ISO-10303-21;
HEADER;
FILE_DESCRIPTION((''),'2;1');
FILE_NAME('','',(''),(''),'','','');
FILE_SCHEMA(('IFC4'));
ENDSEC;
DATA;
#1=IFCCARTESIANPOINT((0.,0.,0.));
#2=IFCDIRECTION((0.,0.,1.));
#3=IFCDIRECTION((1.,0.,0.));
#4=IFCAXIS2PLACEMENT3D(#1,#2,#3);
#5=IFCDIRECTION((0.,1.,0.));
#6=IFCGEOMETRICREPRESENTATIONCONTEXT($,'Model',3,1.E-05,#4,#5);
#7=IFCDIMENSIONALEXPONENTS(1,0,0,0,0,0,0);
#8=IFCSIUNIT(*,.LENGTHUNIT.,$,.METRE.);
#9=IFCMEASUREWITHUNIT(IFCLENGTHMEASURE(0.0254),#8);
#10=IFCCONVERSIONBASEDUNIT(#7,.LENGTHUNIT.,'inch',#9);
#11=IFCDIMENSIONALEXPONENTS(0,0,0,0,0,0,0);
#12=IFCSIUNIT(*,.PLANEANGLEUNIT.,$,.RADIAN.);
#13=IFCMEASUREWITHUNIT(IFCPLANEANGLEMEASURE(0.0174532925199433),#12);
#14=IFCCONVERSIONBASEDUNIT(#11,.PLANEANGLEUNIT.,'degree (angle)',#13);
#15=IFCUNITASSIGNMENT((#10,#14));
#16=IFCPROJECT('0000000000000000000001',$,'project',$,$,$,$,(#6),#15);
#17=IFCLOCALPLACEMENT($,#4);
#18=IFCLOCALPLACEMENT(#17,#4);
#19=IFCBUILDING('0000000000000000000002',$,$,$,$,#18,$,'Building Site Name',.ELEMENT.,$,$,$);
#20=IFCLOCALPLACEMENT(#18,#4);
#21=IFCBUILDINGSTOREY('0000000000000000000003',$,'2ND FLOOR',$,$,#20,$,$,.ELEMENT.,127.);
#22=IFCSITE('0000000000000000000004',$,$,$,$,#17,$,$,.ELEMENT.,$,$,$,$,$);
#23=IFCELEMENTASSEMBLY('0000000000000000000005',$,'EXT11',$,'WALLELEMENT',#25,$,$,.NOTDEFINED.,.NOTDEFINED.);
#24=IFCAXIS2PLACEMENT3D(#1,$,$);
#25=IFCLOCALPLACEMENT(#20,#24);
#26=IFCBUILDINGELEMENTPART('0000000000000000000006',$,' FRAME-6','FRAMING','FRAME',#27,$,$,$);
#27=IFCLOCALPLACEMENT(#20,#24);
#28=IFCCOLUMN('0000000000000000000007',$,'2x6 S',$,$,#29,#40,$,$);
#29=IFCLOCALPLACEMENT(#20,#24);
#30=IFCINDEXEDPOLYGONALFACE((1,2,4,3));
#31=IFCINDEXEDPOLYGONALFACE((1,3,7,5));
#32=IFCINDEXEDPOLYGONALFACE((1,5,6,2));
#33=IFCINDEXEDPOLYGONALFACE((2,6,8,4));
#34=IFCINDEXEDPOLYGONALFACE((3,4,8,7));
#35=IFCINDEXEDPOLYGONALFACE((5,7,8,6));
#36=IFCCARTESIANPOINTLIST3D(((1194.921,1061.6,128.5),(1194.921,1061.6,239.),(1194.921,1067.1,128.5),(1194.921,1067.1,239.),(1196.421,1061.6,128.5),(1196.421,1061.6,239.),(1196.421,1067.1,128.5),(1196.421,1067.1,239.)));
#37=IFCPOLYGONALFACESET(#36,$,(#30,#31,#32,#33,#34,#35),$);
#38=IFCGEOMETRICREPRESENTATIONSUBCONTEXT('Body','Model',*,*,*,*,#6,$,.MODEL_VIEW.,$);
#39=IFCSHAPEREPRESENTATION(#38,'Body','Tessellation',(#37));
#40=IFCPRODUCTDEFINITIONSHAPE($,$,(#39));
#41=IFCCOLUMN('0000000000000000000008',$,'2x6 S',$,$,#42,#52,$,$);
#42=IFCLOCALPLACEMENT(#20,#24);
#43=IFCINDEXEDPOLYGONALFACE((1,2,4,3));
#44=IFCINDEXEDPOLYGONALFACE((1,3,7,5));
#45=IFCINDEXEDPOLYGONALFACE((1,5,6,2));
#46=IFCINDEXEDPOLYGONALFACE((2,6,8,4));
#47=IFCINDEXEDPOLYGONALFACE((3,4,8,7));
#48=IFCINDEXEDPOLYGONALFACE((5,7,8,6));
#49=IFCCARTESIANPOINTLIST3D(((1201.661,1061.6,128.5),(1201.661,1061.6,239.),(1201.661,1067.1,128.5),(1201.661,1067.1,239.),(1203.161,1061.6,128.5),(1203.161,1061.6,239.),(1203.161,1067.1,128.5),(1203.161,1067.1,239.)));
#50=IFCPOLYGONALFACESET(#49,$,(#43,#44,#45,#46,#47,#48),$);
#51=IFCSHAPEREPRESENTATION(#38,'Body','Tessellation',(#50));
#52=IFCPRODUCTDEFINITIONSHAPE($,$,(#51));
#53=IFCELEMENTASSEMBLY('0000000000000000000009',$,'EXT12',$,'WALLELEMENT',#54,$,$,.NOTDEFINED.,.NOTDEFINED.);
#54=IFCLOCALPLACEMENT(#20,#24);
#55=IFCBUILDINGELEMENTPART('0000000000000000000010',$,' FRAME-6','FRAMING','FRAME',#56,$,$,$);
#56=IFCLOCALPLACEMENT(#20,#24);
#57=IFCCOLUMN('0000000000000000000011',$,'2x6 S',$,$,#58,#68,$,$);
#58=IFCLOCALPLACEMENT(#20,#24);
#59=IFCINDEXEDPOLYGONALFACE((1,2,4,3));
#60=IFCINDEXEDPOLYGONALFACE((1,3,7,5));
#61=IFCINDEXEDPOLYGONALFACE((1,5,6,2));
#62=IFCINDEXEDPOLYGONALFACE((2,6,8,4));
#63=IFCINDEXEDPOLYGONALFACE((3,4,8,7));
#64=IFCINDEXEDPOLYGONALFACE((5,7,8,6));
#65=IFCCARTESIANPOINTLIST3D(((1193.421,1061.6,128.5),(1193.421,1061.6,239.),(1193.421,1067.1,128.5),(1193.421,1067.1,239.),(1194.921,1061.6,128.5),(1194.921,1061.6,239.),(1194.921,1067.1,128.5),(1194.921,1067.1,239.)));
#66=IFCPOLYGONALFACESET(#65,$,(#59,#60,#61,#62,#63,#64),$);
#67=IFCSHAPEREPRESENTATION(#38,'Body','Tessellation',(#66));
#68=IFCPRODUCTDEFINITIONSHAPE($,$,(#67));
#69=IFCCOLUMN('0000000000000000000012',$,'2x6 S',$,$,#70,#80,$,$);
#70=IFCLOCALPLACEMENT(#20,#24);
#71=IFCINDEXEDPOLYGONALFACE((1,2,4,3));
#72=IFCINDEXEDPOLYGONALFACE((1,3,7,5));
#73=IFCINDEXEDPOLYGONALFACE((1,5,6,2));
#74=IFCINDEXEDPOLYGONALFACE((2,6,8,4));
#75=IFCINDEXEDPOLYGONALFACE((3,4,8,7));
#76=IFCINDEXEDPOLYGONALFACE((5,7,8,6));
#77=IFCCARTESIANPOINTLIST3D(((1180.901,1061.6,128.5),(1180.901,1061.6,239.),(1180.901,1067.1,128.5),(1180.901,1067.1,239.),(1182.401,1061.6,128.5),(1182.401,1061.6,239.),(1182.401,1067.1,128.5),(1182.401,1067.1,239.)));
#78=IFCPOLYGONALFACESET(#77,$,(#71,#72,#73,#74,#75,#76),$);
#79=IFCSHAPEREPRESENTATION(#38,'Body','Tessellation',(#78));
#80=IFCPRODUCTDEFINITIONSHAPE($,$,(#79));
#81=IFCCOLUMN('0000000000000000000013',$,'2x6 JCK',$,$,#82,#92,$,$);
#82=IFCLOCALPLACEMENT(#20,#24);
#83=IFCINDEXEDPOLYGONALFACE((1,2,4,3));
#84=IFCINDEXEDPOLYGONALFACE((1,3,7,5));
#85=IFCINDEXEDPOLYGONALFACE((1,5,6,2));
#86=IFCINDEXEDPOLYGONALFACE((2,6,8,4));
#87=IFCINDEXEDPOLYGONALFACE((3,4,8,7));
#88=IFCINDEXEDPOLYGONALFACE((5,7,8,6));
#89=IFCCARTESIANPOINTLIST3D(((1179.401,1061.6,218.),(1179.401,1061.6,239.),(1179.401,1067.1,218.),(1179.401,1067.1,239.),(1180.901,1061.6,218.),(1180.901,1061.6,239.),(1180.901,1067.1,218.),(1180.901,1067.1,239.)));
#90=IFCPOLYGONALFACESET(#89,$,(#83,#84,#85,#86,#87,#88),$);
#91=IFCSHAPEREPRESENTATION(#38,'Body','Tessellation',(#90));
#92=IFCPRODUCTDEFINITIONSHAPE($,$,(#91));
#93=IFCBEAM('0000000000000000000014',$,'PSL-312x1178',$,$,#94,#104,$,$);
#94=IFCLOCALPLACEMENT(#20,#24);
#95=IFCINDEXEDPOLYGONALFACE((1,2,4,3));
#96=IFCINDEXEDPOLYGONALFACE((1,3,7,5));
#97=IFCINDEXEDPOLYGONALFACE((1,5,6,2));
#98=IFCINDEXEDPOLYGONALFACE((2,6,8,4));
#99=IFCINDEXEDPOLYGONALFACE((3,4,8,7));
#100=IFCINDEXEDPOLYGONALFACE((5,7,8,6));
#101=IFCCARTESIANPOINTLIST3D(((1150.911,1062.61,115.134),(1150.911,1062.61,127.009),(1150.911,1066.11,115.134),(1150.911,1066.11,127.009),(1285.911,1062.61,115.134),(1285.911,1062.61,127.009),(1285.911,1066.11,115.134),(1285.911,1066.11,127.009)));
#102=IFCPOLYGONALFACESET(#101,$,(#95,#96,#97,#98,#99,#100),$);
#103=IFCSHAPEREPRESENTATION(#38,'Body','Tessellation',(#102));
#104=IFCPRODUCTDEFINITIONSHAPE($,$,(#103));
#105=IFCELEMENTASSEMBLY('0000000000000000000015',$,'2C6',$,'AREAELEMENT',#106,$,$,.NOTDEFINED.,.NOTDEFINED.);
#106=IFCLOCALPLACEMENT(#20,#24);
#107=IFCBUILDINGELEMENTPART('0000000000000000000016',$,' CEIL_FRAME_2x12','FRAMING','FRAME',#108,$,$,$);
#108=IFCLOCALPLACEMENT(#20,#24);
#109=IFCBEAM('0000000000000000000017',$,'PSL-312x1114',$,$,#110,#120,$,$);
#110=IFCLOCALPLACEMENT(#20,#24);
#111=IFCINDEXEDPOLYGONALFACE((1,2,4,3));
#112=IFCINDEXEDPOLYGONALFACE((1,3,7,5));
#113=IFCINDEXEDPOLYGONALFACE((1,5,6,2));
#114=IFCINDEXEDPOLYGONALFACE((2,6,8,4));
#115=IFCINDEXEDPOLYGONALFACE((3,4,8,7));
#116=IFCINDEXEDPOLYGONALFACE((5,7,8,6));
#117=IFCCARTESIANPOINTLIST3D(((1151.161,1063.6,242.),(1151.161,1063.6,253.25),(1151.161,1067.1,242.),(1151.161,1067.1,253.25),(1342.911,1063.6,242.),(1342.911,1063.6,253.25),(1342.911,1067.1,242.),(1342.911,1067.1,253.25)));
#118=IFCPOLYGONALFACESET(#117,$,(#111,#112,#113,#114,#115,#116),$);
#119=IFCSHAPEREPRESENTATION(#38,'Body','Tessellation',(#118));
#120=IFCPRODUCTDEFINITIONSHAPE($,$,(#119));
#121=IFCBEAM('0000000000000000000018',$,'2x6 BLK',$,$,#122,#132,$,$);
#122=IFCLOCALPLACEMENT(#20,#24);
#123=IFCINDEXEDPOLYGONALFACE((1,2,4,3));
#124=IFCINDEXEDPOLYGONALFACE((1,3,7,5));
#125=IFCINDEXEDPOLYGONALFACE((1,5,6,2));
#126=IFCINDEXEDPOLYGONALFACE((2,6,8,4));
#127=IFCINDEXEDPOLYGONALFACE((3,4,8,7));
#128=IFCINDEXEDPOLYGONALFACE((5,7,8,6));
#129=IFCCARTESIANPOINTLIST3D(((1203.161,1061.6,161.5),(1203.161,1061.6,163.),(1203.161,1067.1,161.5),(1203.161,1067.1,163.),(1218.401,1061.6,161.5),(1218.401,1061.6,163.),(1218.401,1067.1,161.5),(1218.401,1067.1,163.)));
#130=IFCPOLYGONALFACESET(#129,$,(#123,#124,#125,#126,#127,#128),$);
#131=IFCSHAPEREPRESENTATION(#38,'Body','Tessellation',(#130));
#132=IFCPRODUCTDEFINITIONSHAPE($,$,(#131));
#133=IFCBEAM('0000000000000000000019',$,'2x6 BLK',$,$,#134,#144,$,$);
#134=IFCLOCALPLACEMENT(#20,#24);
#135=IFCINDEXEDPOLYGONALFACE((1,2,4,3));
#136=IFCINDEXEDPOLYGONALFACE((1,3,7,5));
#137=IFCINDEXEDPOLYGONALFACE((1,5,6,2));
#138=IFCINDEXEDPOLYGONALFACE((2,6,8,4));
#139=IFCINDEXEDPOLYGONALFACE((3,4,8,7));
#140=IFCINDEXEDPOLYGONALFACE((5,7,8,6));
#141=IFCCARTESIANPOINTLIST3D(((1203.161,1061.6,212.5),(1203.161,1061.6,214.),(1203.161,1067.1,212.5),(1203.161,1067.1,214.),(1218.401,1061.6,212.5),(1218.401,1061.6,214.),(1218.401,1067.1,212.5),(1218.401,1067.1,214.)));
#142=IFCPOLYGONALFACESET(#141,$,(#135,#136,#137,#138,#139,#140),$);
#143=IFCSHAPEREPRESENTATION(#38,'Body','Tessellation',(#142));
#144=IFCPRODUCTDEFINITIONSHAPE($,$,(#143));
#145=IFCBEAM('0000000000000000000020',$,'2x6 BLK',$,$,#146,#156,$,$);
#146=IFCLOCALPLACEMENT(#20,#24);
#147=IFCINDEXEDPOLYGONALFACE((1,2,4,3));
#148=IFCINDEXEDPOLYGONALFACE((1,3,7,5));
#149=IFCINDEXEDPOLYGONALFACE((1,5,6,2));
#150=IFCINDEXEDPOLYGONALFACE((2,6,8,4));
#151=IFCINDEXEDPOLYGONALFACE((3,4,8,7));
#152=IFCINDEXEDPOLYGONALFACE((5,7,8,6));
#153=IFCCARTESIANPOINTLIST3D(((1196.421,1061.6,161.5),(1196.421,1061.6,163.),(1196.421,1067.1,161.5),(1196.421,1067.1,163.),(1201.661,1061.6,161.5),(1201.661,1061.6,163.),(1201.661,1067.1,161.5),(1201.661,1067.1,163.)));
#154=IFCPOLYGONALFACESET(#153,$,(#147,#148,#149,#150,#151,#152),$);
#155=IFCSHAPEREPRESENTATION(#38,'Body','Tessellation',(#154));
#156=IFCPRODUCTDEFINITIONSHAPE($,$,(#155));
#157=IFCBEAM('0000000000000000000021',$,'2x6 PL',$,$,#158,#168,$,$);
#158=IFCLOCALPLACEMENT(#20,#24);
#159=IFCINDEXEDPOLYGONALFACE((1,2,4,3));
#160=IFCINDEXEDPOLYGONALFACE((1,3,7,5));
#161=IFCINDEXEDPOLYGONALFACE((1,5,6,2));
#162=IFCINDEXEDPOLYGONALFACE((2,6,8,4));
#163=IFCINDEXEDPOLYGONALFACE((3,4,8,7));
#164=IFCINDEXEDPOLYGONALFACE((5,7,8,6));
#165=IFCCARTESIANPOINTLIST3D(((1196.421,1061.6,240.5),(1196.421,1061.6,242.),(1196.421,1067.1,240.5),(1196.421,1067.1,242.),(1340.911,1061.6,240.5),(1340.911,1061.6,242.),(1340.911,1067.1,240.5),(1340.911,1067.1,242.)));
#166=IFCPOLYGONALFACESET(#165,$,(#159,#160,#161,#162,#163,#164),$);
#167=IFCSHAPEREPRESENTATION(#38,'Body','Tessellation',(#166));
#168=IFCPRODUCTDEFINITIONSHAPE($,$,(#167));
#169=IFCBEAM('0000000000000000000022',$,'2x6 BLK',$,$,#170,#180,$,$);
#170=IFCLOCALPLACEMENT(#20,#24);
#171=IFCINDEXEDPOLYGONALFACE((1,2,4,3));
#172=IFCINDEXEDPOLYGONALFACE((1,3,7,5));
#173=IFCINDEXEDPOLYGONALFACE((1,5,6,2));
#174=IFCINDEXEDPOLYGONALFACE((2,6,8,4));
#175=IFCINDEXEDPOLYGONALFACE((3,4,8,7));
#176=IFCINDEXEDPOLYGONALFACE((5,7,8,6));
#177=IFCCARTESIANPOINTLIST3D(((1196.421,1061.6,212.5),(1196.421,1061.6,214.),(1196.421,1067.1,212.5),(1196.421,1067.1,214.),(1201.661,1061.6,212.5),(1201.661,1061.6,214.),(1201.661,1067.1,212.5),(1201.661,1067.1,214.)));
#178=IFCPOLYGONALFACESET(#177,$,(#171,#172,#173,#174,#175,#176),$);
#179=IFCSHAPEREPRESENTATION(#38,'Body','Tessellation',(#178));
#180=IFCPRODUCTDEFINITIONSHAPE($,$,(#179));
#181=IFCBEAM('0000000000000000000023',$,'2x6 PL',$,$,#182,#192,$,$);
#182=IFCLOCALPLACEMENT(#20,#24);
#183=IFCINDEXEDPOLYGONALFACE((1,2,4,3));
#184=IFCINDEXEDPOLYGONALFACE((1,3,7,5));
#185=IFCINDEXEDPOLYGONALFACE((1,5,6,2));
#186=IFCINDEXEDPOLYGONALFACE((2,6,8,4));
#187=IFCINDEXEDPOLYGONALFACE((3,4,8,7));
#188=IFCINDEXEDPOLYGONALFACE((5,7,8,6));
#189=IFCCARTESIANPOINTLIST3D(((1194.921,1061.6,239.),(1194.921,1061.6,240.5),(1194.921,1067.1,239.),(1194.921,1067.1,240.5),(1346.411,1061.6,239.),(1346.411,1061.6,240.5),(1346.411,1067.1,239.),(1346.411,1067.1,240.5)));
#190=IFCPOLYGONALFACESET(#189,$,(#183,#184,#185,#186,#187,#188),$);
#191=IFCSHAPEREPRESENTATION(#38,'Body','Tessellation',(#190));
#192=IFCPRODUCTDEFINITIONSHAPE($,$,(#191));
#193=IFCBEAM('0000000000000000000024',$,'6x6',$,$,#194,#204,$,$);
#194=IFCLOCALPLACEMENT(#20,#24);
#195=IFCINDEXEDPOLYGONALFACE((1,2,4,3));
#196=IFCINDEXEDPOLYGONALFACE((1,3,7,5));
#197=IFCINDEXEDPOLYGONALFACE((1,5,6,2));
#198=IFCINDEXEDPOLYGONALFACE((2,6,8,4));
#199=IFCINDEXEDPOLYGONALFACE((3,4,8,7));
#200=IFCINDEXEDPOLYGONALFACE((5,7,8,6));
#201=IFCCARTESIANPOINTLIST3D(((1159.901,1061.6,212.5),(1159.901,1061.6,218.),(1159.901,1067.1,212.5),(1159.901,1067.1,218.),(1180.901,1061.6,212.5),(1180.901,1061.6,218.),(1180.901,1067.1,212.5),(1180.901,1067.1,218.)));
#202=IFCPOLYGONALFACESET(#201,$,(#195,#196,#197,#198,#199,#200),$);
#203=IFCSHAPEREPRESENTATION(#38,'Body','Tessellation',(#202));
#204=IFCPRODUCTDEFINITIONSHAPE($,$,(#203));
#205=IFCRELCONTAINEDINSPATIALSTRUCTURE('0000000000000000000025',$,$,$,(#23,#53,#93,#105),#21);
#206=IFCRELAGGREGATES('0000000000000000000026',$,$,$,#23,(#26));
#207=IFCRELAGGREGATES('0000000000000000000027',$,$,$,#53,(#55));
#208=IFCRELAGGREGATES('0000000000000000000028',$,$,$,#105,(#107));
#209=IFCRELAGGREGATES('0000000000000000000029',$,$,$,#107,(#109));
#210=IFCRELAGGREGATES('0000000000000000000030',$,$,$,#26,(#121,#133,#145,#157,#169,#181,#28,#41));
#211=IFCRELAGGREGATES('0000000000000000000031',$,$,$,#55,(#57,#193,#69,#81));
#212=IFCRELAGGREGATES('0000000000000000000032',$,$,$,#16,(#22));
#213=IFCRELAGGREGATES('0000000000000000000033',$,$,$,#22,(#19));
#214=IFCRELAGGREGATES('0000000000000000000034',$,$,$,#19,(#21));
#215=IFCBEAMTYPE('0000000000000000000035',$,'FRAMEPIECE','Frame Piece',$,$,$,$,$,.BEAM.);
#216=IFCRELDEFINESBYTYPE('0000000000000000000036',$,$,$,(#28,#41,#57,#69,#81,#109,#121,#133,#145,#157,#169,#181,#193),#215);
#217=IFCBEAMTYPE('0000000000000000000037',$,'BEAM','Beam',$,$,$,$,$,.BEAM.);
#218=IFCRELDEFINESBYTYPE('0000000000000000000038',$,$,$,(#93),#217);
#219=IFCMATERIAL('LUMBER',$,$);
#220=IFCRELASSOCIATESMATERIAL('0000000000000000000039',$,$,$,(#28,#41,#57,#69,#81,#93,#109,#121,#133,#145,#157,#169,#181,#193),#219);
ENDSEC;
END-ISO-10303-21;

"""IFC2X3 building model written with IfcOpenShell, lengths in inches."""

from ifc_helpers import new_model, entity, si_unit, converted_unit, direction, frame, frame_2d, origin_with_axes, place, context, subcontext, project, spatial, rectangle, extrude, material, type_object, element, aggregate, save


model = new_model("IFC2X3")

# Units and contexts
model_context = context("Model", 3, precision=1e-05, world=origin_with_axes(), true_north=direction((0.0, 1.0, 0.0)))
body_context = subcontext(model_context, "Body", "Model", "MODEL_VIEW")
ifc_project = project(units=[converted_unit("LENGTHUNIT", "inch", entity("IfcLengthMeasure", 0.0254), si_unit("LENGTHUNIT", "METRE"), dimensions=[1, 0, 0, 0, 0, 0, 0]), converted_unit("PLANEANGLEUNIT", "degree (angle)", entity("IfcPlaneAngleMeasure", 0.0174532925199433), si_unit("PLANEANGLEUNIT", "RADIAN"), dimensions=[0, 0, 0, 0, 0, 0, 0])], contexts=[model_context])

# Site, building, storey
site_placement = place(None, origin_with_axes())
site = spatial("IfcSite", under=ifc_project, at=site_placement, CompositionType="ELEMENT")
building_placement = place(site_placement, origin_with_axes())
building = spatial("IfcBuilding", under=site, at=building_placement, LongName="Building Site Name", CompositionType="ELEMENT")
storey_placement = place(building_placement, origin_with_axes())
storey = spatial("IfcBuildingStorey", under=building, at=storey_placement, Name="2ND FLOOR", CompositionType="ELEMENT", Elevation=127.0)

# Element assemblies, building element parts, columns
assembly_1_placement = place(storey_placement, origin_with_axes())
assembly_1 = element("IfcElementAssembly", 1, at=assembly_1_placement, inside=storey, Name="EXT11", ObjectType="WALLELEMENT", AssemblyPlace="NOTDEFINED", PredefinedType="NOTDEFINED")
building_element_part_1 = element("IfcBuildingElementPart", 2, Name=" FRAME-6", Description="FRAMING", ObjectType="FRAME")
aggregate(assembly_1, [building_element_part_1])
ifc_material_1 = material(Name="LUMBER")
beam_type_1 = type_object("IfcBeamType", Name="FRAMEPIECE", Description="Frame Piece", PredefinedType="BEAM")
column_1_placement = place(assembly_1_placement, frame((1195.671, 1064.35, 128.5), z_axis=(0.0, 0.0, 1.0), x_axis=(1.0, 0.0, 0.0)))
column_1 = element("IfcColumn", 3, at=column_1_placement, type_object=beam_type_1, material=ifc_material_1, Name="2x6 S", context=body_context, shape_type="SweptSolid", body=[
    extrude(rectangle(XDim=1.5, YDim=5.5, at=frame_2d((0.0, 0.0), x_axis=(-1.0, 0.0))), origin_with_axes(), (0.0, 0.0, 1.0), 110.5),
])
column_2_placement = place(assembly_1_placement, frame((1202.411, 1064.35, 239.0), z_axis=(0.0, 0.0, -1.0), x_axis=(-1.0, 0.0, 0.0)))
column_2 = element("IfcColumn", 4, at=column_2_placement, type_object=beam_type_1, material=ifc_material_1, Name="2x6 S", context=body_context, shape_type="SweptSolid", body=[
    extrude(rectangle(XDim=1.5, YDim=5.5, at=frame_2d((0.0, 0.0), x_axis=(-1.0, 0.0))), origin_with_axes(), (0.0, 0.0, 1.0), 110.5),
])
assembly_2_placement = place(storey_placement, origin_with_axes())
assembly_2 = element("IfcElementAssembly", 5, at=assembly_2_placement, inside=storey, Name="EXT12", ObjectType="WALLELEMENT", AssemblyPlace="NOTDEFINED", PredefinedType="NOTDEFINED")
building_element_part_2 = element("IfcBuildingElementPart", 6, Name=" FRAME-6", Description="FRAMING", ObjectType="FRAME")
aggregate(assembly_2, [building_element_part_2])
column_3_placement = place(assembly_2_placement, frame((1194.171, 1064.35, 239.0), z_axis=(0.0, 0.0, -1.0), x_axis=(-1.0, 0.0, 0.0)))
column_3 = element("IfcColumn", 7, at=column_3_placement, type_object=beam_type_1, material=ifc_material_1, Name="2x6 S", context=body_context, shape_type="SweptSolid", body=[
    extrude(rectangle(XDim=1.5, YDim=5.5, at=frame_2d((0.0, 0.0), x_axis=(-1.0, 0.0))), origin_with_axes(), (0.0, 0.0, 1.0), 110.5),
])
column_4_placement = place(assembly_2_placement, frame((1181.651, 1064.35, 239.0), z_axis=(0.0, 0.0, -1.0), x_axis=(-1.0, 0.0, 0.0)))
column_4 = element("IfcColumn", 8, at=column_4_placement, type_object=beam_type_1, material=ifc_material_1, Name="2x6 S", context=body_context, shape_type="SweptSolid", body=[
    extrude(rectangle(XDim=1.5, YDim=5.5, at=frame_2d((0.0, 0.0), x_axis=(-1.0, 0.0))), origin_with_axes(), (0.0, 0.0, 1.0), 110.5),
])
column_5_placement = place(assembly_2_placement, frame((1180.151, 1064.35, 239.0), z_axis=(0.0, 0.0, -1.0), x_axis=(-1.0, 0.0, 0.0)))
column_5 = element("IfcColumn", 9, at=column_5_placement, type_object=beam_type_1, material=ifc_material_1, Name="2x6 JCK", context=body_context, shape_type="SweptSolid", body=[
    extrude(rectangle(XDim=1.5, YDim=5.5, at=frame_2d((0.0, 0.0), x_axis=(-1.0, 0.0))), origin_with_axes(), (0.0, 0.0, 1.0), 21.0),
])

# Beam
beam_type_2 = type_object("IfcBeamType", Name="BEAM", Description="Beam", PredefinedType="BEAM")
beam_1_placement = place(storey_placement, frame((1150.911, 1064.36, 121.071), z_axis=(1.0, 0.0, 0.0), x_axis=(0.0, 1.0, 0.0)))
element("IfcBeam", 10, at=beam_1_placement, inside=storey, type_object=beam_type_2, material=ifc_material_1, Name="PSL-312x1178", context=body_context, shape_type="SweptSolid", body=[
    extrude(rectangle(XDim=3.5, YDim=11.875, at=frame_2d((0.0, 0.0), x_axis=(-1.0, 0.0))), origin_with_axes(), (0.0, 0.0, 1.0), 135.0),
])

# Element assembly, building element part, beam
assembly_3_placement = place(storey_placement, origin_with_axes())
assembly_3 = element("IfcElementAssembly", 11, at=assembly_3_placement, inside=storey, Name="2C6", ObjectType="AREAELEMENT", AssemblyPlace="NOTDEFINED", PredefinedType="NOTDEFINED")
building_element_part_3 = element("IfcBuildingElementPart", 12, Name=" CEIL_FRAME_2x12", Description="FRAMING", ObjectType="FRAME")
aggregate(assembly_3, [building_element_part_3])
beam_2_placement = place(assembly_3_placement, frame((1151.161, 1065.35, 247.625), z_axis=(1.0, 0.0, 0.0), x_axis=(0.0, 1.0, 0.0)))
beam_2 = element("IfcBeam", 13, at=beam_2_placement, type_object=beam_type_1, material=ifc_material_1, Name="PSL-312x1114", context=body_context, shape_type="SweptSolid", body=[
    extrude(rectangle(XDim=3.5, YDim=11.25, at=frame_2d((0.0, 0.0), x_axis=(-1.0, 0.0))), origin_with_axes(), (0.0, 0.0, 1.0), 191.75),
])
aggregate(building_element_part_3, [beam_2])

# Beams
beam_3_placement = place(assembly_1_placement, frame((1203.161, 1064.35, 162.25), z_axis=(1.0, 0.0, 0.0), x_axis=(0.0, 0.0, -1.0)))
beam_3 = element("IfcBeam", 14, at=beam_3_placement, type_object=beam_type_1, material=ifc_material_1, Name="2x6 BLK", context=body_context, shape_type="SweptSolid", body=[
    extrude(rectangle(XDim=1.5, YDim=5.5, at=frame_2d((0.0, 0.0), x_axis=(-1.0, 0.0))), origin_with_axes(), (0.0, 0.0, 1.0), 15.24),
])
beam_4_placement = place(assembly_1_placement, frame((1203.161, 1064.35, 213.25), z_axis=(1.0, 0.0, 0.0), x_axis=(0.0, 0.0, -1.0)))
beam_4 = element("IfcBeam", 15, at=beam_4_placement, type_object=beam_type_1, material=ifc_material_1, Name="2x6 BLK", context=body_context, shape_type="SweptSolid", body=[
    extrude(rectangle(XDim=1.5, YDim=5.5, at=frame_2d((0.0, 0.0), x_axis=(-1.0, 0.0))), origin_with_axes(), (0.0, 0.0, 1.0), 15.24),
])
beam_5_placement = place(assembly_1_placement, frame((1196.421, 1064.35, 162.25), z_axis=(1.0, 0.0, 0.0), x_axis=(0.0, 0.0, -1.0)))
beam_5 = element("IfcBeam", 16, at=beam_5_placement, type_object=beam_type_1, material=ifc_material_1, Name="2x6 BLK", context=body_context, shape_type="SweptSolid", body=[
    extrude(rectangle(XDim=1.5, YDim=5.5, at=frame_2d((0.0, 0.0), x_axis=(-1.0, 0.0))), origin_with_axes(), (0.0, 0.0, 1.0), 5.24),
])
beam_6_placement = place(assembly_1_placement, frame((1196.421, 1064.35, 241.25), z_axis=(1.0, 0.0, 0.0), x_axis=(0.0, 0.0, -1.0)))
beam_6 = element("IfcBeam", 17, at=beam_6_placement, type_object=beam_type_1, material=ifc_material_1, Name="2x6 PL", context=body_context, shape_type="SweptSolid", body=[
    extrude(rectangle(XDim=1.5, YDim=5.5, at=frame_2d((0.0, 0.0), x_axis=(-1.0, 0.0))), origin_with_axes(), (0.0, 0.0, 1.0), 144.49),
])
beam_7_placement = place(assembly_1_placement, frame((1196.421, 1064.35, 213.25), z_axis=(1.0, 0.0, 0.0), x_axis=(0.0, 0.0, -1.0)))
beam_7 = element("IfcBeam", 18, at=beam_7_placement, type_object=beam_type_1, material=ifc_material_1, Name="2x6 BLK", context=body_context, shape_type="SweptSolid", body=[
    extrude(rectangle(XDim=1.5, YDim=5.5, at=frame_2d((0.0, 0.0), x_axis=(-1.0, 0.0))), origin_with_axes(), (0.0, 0.0, 1.0), 5.24),
])
beam_8_placement = place(assembly_1_placement, frame((1194.921, 1064.35, 239.75), z_axis=(1.0, 0.0, 0.0), x_axis=(0.0, 0.0, -1.0)))
beam_8 = element("IfcBeam", 19, at=beam_8_placement, type_object=beam_type_1, material=ifc_material_1, Name="2x6 PL", context=body_context, shape_type="SweptSolid", body=[
    extrude(rectangle(XDim=1.5, YDim=5.5, at=frame_2d((0.0, 0.0), x_axis=(-1.0, 0.0))), frame((0.0, 0.0, 0.0), z_axis=(0.0, 0.0, 1.0), x_axis=(1.0, 0.0, 0.0)), (0.0, 0.0, 1.0), 151.49),
])
aggregate(building_element_part_1, [beam_3, beam_4, beam_5, beam_6, beam_7, beam_8, column_1, column_2])
beam_9_placement = place(assembly_2_placement, frame((1180.901, 1064.35, 215.25), z_axis=(-1.0, 0.0, 0.0), x_axis=(0.0, -1.0, 0.0)))
beam_9 = element("IfcBeam", 20, at=beam_9_placement, type_object=beam_type_1, material=ifc_material_1, Name="6x6", context=body_context, shape_type="SweptSolid", body=[
    extrude(rectangle(XDim=5.5, YDim=5.5, at=frame_2d((0.0, 0.0), x_axis=(-1.0, 0.0))), frame((0.0, 0.0, 0.0), z_axis=(0.0, 0.0, 1.0), x_axis=(1.0, 0.0, 0.0)), (0.0, 0.0, 1.0), 21.0),
])
aggregate(building_element_part_2, [column_3, beam_9, column_4, column_5])

save(model, "model.ifc")
